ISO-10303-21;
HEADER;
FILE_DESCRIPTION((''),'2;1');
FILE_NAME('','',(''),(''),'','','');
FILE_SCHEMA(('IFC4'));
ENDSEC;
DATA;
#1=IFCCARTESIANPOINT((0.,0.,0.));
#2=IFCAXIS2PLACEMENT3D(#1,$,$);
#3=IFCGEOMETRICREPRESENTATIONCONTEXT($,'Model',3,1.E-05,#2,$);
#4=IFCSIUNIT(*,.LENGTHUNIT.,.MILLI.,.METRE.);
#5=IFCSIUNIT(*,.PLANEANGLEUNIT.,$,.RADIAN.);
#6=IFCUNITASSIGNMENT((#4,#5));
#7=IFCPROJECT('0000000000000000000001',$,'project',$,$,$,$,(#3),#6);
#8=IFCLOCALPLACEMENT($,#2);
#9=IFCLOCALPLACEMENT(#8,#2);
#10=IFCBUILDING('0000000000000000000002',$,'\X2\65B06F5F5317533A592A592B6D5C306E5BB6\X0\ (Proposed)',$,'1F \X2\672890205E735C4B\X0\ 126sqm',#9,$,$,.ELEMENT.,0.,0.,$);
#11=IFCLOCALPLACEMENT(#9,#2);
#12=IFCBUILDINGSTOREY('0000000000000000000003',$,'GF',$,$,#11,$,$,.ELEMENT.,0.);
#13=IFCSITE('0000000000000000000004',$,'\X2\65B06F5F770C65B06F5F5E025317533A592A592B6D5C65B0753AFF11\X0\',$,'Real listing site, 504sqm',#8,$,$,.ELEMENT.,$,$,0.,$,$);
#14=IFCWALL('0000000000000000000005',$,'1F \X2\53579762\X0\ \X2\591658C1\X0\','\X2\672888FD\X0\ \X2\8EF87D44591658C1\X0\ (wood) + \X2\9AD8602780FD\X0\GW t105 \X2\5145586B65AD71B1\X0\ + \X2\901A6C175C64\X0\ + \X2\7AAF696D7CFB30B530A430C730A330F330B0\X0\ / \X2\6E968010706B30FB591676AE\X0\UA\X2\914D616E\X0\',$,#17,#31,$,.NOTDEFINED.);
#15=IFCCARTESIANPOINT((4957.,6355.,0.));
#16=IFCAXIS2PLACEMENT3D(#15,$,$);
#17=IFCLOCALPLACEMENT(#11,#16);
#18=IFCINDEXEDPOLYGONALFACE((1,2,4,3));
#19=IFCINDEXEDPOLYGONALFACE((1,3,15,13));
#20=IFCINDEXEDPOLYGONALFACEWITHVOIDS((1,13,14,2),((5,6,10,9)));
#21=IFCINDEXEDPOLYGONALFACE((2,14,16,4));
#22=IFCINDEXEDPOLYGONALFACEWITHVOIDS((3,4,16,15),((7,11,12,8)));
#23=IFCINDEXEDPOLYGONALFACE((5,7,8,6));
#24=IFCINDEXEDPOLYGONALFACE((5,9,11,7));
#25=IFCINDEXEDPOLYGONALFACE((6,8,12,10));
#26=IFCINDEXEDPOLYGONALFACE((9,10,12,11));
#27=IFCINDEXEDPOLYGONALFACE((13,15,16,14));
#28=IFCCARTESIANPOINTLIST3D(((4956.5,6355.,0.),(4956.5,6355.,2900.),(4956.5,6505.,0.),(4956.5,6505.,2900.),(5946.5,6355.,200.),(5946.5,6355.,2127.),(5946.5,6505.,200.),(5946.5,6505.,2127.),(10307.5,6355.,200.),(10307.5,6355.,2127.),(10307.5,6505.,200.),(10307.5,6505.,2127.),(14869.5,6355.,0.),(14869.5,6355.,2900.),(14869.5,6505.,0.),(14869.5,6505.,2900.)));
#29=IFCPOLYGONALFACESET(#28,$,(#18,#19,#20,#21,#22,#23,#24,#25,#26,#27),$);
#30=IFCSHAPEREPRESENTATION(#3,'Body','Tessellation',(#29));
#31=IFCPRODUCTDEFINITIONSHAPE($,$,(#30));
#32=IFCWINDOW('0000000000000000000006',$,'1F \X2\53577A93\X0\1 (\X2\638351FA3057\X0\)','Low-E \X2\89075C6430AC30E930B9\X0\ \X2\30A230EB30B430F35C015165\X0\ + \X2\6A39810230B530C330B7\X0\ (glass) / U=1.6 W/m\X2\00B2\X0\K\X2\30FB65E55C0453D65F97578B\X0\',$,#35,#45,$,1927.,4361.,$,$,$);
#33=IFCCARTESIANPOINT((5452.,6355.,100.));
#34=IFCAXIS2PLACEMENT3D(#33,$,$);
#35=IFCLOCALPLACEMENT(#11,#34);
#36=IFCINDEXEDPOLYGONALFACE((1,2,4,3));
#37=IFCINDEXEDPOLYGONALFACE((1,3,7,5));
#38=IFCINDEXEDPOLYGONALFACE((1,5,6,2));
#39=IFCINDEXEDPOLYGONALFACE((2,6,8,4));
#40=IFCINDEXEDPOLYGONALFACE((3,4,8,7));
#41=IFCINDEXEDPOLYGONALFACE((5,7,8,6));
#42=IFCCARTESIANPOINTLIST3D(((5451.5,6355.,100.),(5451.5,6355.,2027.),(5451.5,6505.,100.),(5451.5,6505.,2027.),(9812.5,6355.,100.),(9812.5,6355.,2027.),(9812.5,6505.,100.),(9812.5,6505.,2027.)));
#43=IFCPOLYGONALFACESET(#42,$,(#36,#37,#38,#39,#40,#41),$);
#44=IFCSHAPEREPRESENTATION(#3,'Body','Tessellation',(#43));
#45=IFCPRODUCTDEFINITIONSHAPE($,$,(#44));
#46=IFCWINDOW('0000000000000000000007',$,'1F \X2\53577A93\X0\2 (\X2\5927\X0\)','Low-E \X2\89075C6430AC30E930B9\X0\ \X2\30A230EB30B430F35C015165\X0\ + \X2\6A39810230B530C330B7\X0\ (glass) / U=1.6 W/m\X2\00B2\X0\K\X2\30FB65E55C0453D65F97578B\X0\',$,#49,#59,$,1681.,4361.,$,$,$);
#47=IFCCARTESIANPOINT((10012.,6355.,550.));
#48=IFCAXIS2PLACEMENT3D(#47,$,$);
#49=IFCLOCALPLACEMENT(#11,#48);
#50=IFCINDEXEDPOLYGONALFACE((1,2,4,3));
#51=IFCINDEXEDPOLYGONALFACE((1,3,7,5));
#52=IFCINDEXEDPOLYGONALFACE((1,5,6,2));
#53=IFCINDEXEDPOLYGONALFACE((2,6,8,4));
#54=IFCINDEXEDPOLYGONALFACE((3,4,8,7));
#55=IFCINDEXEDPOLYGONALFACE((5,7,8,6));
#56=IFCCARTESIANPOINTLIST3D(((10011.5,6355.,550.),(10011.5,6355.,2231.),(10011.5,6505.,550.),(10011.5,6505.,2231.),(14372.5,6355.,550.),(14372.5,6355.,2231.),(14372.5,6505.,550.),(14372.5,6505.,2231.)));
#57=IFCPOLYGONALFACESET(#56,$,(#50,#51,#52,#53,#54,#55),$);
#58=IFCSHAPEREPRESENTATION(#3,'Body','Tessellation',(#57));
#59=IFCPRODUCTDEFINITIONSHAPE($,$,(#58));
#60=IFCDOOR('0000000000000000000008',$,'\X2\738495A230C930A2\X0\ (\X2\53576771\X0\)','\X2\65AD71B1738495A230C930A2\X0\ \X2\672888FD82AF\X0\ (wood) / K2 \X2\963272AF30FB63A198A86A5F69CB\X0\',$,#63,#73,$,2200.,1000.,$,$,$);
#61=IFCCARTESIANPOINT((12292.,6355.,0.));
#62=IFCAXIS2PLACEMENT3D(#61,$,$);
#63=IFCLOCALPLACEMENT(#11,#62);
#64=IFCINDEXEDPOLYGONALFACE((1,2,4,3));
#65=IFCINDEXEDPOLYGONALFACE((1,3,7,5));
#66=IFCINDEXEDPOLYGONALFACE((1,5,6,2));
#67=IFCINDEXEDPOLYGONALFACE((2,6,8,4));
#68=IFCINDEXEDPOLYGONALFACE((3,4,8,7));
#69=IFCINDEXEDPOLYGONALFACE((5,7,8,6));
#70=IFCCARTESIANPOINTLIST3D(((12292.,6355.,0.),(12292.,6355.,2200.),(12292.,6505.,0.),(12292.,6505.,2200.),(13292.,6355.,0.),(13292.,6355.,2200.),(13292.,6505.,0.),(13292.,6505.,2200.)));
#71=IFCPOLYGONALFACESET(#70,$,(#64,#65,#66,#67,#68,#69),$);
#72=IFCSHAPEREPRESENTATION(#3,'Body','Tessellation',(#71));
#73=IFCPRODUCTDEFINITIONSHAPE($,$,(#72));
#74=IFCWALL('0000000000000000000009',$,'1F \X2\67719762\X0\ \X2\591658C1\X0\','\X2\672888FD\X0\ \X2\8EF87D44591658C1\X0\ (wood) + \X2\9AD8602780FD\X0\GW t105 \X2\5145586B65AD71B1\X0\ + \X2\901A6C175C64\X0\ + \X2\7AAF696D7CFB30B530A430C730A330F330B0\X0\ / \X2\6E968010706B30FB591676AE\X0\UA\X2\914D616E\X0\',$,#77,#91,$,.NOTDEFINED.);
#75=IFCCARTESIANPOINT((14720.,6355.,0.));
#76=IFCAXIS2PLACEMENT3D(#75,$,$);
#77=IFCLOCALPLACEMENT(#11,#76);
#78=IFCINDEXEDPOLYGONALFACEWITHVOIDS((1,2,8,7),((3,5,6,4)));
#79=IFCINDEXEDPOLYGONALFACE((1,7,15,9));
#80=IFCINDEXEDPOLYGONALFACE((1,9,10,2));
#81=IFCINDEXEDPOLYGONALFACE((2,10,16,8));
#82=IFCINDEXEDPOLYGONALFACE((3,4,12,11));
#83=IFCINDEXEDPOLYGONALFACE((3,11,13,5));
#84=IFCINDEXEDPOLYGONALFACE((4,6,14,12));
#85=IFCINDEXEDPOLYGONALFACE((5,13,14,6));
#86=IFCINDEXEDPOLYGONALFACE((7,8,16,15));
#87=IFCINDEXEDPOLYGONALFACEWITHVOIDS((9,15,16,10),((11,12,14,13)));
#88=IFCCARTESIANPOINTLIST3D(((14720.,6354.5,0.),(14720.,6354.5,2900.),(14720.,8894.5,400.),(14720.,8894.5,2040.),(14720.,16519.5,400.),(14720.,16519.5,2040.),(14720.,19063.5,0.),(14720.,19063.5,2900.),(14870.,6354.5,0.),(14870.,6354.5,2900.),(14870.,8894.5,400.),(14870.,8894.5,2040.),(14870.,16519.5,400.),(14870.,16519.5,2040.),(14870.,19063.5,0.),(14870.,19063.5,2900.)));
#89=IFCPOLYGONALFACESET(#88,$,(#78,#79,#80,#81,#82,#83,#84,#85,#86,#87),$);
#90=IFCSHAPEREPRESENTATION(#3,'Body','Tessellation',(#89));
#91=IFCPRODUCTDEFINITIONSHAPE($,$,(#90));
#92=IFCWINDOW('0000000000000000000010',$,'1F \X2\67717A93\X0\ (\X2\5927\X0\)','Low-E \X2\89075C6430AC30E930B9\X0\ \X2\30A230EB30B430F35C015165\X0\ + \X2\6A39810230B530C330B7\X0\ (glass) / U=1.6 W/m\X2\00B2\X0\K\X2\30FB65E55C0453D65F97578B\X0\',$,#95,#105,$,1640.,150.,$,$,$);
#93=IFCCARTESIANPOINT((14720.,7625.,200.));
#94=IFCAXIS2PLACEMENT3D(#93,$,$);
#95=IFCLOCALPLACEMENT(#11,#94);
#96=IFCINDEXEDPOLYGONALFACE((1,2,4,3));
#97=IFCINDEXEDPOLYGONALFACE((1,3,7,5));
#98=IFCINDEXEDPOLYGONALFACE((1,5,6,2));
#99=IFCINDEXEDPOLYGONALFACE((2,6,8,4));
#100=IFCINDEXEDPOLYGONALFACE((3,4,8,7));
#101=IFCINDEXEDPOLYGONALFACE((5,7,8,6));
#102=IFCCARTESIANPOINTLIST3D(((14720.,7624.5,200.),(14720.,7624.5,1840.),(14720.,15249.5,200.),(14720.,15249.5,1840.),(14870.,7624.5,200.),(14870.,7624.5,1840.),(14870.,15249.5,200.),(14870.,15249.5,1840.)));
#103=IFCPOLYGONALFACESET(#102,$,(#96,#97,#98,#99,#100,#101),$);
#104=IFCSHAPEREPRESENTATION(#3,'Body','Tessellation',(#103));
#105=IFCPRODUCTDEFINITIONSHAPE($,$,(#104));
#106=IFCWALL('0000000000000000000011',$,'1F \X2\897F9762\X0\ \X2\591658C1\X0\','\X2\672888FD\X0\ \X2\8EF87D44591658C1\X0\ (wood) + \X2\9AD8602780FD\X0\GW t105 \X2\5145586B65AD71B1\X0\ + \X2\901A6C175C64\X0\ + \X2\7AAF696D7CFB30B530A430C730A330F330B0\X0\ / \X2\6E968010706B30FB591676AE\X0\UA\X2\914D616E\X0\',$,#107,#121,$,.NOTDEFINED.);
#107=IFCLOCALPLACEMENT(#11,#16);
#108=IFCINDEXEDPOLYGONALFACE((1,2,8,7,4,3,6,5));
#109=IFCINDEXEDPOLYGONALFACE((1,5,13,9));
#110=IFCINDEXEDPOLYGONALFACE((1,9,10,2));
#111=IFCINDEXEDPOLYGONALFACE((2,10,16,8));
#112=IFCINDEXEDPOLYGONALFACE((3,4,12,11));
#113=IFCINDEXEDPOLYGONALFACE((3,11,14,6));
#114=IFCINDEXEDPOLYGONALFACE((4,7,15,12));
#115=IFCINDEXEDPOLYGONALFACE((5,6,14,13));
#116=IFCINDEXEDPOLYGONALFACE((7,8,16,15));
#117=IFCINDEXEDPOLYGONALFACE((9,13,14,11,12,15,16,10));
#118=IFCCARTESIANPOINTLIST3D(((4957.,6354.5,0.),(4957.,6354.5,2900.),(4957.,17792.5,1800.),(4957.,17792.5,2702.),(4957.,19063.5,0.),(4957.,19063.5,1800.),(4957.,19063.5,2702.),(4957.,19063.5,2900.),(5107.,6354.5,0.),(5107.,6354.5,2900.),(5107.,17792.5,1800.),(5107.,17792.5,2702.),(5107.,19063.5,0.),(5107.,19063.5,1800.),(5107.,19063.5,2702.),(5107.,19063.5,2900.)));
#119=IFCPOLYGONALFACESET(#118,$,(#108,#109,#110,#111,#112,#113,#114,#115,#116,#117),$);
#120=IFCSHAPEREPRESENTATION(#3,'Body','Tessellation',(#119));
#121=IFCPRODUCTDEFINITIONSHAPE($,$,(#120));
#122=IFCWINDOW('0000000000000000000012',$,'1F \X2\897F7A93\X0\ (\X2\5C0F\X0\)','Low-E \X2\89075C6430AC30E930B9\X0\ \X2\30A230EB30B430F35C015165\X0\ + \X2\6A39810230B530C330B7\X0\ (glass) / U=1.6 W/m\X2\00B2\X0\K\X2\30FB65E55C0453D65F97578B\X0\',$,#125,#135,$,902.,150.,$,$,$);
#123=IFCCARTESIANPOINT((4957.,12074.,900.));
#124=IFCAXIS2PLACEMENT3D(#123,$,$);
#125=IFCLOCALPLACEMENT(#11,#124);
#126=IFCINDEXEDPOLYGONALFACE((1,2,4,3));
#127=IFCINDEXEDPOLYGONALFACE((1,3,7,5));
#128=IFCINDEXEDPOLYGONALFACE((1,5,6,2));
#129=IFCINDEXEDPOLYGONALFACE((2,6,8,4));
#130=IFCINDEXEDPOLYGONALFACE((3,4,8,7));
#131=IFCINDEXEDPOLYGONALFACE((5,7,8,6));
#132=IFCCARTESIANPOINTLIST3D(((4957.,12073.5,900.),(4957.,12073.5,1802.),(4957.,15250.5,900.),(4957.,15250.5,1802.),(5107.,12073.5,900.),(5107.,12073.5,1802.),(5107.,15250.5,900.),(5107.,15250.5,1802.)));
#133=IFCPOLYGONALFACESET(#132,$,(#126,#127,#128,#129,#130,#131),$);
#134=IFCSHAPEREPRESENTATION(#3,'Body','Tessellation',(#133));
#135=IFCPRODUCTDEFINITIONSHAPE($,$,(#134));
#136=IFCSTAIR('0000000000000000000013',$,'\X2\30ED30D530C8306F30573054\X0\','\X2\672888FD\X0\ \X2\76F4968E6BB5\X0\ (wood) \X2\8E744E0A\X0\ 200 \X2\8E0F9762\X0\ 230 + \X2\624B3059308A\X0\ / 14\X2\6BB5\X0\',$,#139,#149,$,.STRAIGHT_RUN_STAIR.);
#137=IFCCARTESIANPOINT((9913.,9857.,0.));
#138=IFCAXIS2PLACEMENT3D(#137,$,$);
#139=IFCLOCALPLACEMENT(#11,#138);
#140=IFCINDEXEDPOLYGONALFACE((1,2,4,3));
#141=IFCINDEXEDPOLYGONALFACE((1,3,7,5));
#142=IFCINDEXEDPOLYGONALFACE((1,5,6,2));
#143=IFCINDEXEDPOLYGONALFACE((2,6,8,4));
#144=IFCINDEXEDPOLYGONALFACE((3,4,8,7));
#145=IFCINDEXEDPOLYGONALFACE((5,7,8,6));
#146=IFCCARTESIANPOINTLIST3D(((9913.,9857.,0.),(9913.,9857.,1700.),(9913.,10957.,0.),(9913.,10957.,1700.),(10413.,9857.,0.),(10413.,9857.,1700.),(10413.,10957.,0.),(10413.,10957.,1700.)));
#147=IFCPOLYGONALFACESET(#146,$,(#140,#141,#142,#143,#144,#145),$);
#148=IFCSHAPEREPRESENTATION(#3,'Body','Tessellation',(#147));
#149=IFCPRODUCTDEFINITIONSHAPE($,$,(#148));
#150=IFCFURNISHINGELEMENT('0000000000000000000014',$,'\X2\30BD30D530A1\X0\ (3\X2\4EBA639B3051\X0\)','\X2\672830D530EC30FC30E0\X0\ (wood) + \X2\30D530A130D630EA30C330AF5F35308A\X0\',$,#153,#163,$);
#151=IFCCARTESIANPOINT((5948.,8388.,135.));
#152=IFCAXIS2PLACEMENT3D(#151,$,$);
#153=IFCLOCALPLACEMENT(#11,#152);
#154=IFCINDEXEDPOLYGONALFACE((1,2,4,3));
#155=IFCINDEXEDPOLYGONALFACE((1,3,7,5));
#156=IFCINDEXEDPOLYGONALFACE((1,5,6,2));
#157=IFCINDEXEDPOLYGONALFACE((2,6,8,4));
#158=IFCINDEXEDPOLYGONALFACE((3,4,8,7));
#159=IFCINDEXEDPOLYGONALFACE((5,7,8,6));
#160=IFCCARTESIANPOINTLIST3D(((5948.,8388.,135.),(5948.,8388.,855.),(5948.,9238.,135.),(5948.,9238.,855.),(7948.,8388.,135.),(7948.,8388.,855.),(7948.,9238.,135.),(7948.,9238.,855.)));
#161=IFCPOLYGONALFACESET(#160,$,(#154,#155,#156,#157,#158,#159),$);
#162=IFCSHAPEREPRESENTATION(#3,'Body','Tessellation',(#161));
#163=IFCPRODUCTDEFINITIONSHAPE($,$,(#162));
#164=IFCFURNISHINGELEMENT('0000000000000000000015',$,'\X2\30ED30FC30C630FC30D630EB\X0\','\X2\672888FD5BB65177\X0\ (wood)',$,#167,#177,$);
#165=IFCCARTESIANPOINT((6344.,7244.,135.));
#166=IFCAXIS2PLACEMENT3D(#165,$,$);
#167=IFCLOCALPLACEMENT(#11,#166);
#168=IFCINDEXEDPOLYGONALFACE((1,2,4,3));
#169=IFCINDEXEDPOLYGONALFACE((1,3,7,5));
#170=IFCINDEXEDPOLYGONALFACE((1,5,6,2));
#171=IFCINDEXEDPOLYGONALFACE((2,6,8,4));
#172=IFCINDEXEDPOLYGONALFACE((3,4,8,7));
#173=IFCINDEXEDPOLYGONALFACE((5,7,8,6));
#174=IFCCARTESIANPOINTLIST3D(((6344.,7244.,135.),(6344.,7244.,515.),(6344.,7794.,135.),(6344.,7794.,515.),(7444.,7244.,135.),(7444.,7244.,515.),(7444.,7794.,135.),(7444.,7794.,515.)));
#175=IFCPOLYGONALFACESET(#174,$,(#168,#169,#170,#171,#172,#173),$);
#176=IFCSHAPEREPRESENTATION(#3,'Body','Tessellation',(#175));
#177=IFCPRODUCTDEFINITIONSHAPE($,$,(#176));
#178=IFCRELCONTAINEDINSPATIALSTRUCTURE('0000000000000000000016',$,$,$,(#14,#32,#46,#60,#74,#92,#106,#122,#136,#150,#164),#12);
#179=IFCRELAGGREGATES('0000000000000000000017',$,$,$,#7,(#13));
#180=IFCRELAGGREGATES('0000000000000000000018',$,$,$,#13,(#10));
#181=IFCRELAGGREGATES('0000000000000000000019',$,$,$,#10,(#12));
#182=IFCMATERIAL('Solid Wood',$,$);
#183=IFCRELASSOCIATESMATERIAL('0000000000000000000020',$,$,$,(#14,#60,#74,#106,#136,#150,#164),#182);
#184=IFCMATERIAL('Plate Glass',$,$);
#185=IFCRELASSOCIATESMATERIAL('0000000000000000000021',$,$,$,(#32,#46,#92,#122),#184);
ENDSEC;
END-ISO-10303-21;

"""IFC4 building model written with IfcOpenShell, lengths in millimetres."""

from ifc_helpers import new_model, si_unit, frame, frame_2d, origin, place, context, project, spatial, rectangle, extrude, material, element, fill, save


model = new_model("IFC4")

# Units and contexts
model_context = context("Model", 3, precision=1e-05, world=origin())
ifc_project = project(units=[si_unit("LENGTHUNIT", "METRE", prefix="MILLI"), si_unit("PLANEANGLEUNIT", "RADIAN")], contexts=[model_context])

# Site, building, storey
site_placement = place(None, origin())
site = spatial("IfcSite", under=ifc_project, at=site_placement, Name="新潟県新潟市北区太夫浜新町１", ObjectType="Real listing site, 504sqm", CompositionType="ELEMENT", RefElevation=0.0)
building_placement = place(site_placement, origin())
building = spatial("IfcBuilding", under=site, at=building_placement, Name="新潟北区太夫浜の家 (Proposed)", ObjectType="1F 木造平屋 126sqm", CompositionType="ELEMENT", ElevationOfRefHeight=0.0, ElevationOfTerrain=0.0)
storey_placement = place(building_placement, origin())
storey = spatial("IfcBuildingStorey", under=building, at=storey_placement, Name="GF", CompositionType="ELEMENT", Elevation=0.0)

# Shared definitions
ifc_material_1 = material(Name="Solid Wood")

# Wall, openings, windows, door
wall_1_placement = place(storey_placement, frame((4957.0, 6355.0, 0.0)))
wall_1 = element("IfcWall", 1, at=wall_1_placement, inside=storey, material=ifc_material_1, Name="1F 南面 外壁", Description="木製 軸組外壁 (wood) + 高性能GW t105 充填断熱 + 通気層 + 窯業系サイディング / 準耐火・外皮UA配慮", PredefinedType="NOTDEFINED", context=model_context, shape_type="SweptSolid", body=[
    extrude(rectangle(XDim=9913.0, YDim=150.0, at=frame_2d((4956.0, 75.0))), frame((4957.0, 6355.0, 0.0)), (0.0, 0.0, 1.0), 2900.0),
])
opening_1_placement = place(storey_placement, frame((5452.0, 6355.0, 100.0)))
opening_1 = element("IfcOpeningElement", 2, at=opening_1_placement, cuts=wall_1, PredefinedType="NOTDEFINED", context=model_context, shape_type="SweptSolid", body=[
    extrude(rectangle(XDim=4361.0, YDim=150.0, at=frame_2d((2180.0, 75.0))), frame((5452.0, 6355.0, 100.0)), (0.0, 0.0, 1.0), 1927.0),
])
opening_2_placement = place(storey_placement, frame((10012.0, 6355.0, 550.0)))
opening_2 = element("IfcOpeningElement", 3, at=opening_2_placement, cuts=wall_1, PredefinedType="NOTDEFINED", context=model_context, shape_type="SweptSolid", body=[
    extrude(rectangle(XDim=4361.0, YDim=150.0, at=frame_2d((2180.0, 75.0))), frame((10012.0, 6355.0, 550.0)), (0.0, 0.0, 1.0), 1681.0),
])
opening_3_placement = place(storey_placement, frame((12292.0, 6355.0, 0.0)))
opening_3 = element("IfcOpeningElement", 4, at=opening_3_placement, cuts=wall_1, PredefinedType="NOTDEFINED", context=model_context, shape_type="SweptSolid", body=[
    extrude(rectangle(XDim=1000.0, YDim=150.0, at=frame_2d((500.0, 75.0))), frame((12292.0, 6355.0, 0.0)), (0.0, 0.0, 1.0), 2200.0),
])
ifc_material_2 = material(Name="Plate Glass")
window_1_placement = place(storey_placement, frame((5452.0, 6355.0, 100.0)))
window_1 = element("IfcWindow", 5, at=window_1_placement, inside=storey, material=ifc_material_2, Name="1F 南窓1 (掃出し)", Description="Low-E 複層ガラス アルゴン封入 + 樹脂サッシ (glass) / U=1.6 W/m²K・日射取得型", OverallHeight=1927.0, OverallWidth=4361.0, context=model_context, shape_type="SweptSolid", body=[
    extrude(rectangle(XDim=4361.0, YDim=150.0, at=frame_2d((2180.0, 75.0))), frame((5452.0, 6355.0, 100.0)), (0.0, 0.0, 1.0), 1927.0),
])
fill(opening_1, window_1)
window_2_placement = place(storey_placement, frame((10012.0, 6355.0, 550.0)))
window_2 = element("IfcWindow", 6, at=window_2_placement, inside=storey, material=ifc_material_2, Name="1F 南窓2 (大)", Description="Low-E 複層ガラス アルゴン封入 + 樹脂サッシ (glass) / U=1.6 W/m²K・日射取得型", OverallHeight=1681.0, OverallWidth=4361.0, context=model_context, shape_type="SweptSolid", body=[
    extrude(rectangle(XDim=4361.0, YDim=150.0, at=frame_2d((2180.0, 75.0))), frame((10012.0, 6355.0, 550.0)), (0.0, 0.0, 1.0), 1681.0),
])
fill(opening_2, window_2)
door_placement = place(storey_placement, frame((12292.0, 6355.0, 0.0)))
door = element("IfcDoor", 7, at=door_placement, inside=storey, material=ifc_material_1, Name="玄関ドア (南東)", Description="断熱玄関ドア 木製芯 (wood) / K2 防犯・採風機構", OverallHeight=2200.0, OverallWidth=1000.0, context=model_context, shape_type="SweptSolid", body=[
    extrude(rectangle(XDim=1000.0, YDim=150.0, at=frame_2d((500.0, 75.0))), frame((12292.0, 6355.0, 0.0)), (0.0, 0.0, 1.0), 2200.0),
])
fill(opening_3, door)

# Walls, openings, windows
wall_2_placement = place(storey_placement, frame((14720.0, 6355.0, 0.0)))
wall_2 = element("IfcWall", 8, at=wall_2_placement, inside=storey, material=ifc_material_1, Name="1F 東面 外壁", Description="木製 軸組外壁 (wood) + 高性能GW t105 充填断熱 + 通気層 + 窯業系サイディング / 準耐火・外皮UA配慮", PredefinedType="NOTDEFINED", context=model_context, shape_type="SweptSolid", body=[
    extrude(rectangle(XDim=150.0, YDim=12709.0, at=frame_2d((75.0, 6354.0))), frame((14720.0, 6355.0, 0.0)), (0.0, 0.0, 1.0), 2900.0),
])
opening_4_placement = place(storey_placement, frame((14720.0, 7625.0, 200.0)))
opening_4 = element("IfcOpeningElement", 9, at=opening_4_placement, cuts=wall_2, PredefinedType="NOTDEFINED", context=model_context, shape_type="SweptSolid", body=[
    extrude(rectangle(XDim=150.0, YDim=7625.0, at=frame_2d((75.0, 3812.0))), frame((14720.0, 7625.0, 200.0)), (0.0, 0.0, 1.0), 1640.0),
])
window_3_placement = place(storey_placement, frame((14720.0, 7625.0, 200.0)))
window_3 = element("IfcWindow", 10, at=window_3_placement, inside=storey, material=ifc_material_2, Name="1F 東窓 (大)", Description="Low-E 複層ガラス アルゴン封入 + 樹脂サッシ (glass) / U=1.6 W/m²K・日射取得型", OverallHeight=1640.0, OverallWidth=150.0, context=model_context, shape_type="SweptSolid", body=[
    extrude(rectangle(XDim=150.0, YDim=7625.0, at=frame_2d((75.0, 3812.0))), frame((14720.0, 7625.0, 200.0)), (0.0, 0.0, 1.0), 1640.0),
])
fill(opening_4, window_3)
wall_3_placement = place(storey_placement, frame((4957.0, 6355.0, 0.0)))
wall_3 = element("IfcWall", 11, at=wall_3_placement, inside=storey, material=ifc_material_1, Name="1F 西面 外壁", Description="木製 軸組外壁 (wood) + 高性能GW t105 充填断熱 + 通気層 + 窯業系サイディング / 準耐火・外皮UA配慮", PredefinedType="NOTDEFINED", context=model_context, shape_type="SweptSolid", body=[
    extrude(rectangle(XDim=150.0, YDim=12709.0, at=frame_2d((75.0, 6354.0))), frame((4957.0, 6355.0, 0.0)), (0.0, 0.0, 1.0), 2900.0),
])
opening_5_placement = place(storey_placement, frame((4957.0, 12074.0, 900.0)))
opening_5 = element("IfcOpeningElement", 12, at=opening_5_placement, cuts=wall_3, PredefinedType="NOTDEFINED", context=model_context, shape_type="SweptSolid", body=[
    extrude(rectangle(XDim=150.0, YDim=3177.0, at=frame_2d((75.0, 1588.0))), frame((4957.0, 12074.0, 900.0)), (0.0, 0.0, 1.0), 902.0),
])
window_4_placement = place(storey_placement, frame((4957.0, 12074.0, 900.0)))
window_4 = element("IfcWindow", 13, at=window_4_placement, inside=storey, material=ifc_material_2, Name="1F 西窓 (小)", Description="Low-E 複層ガラス アルゴン封入 + 樹脂サッシ (glass) / U=1.6 W/m²K・日射取得型", OverallHeight=902.0, OverallWidth=150.0, context=model_context, shape_type="SweptSolid", body=[
    extrude(rectangle(XDim=150.0, YDim=3177.0, at=frame_2d((75.0, 1588.0))), frame((4957.0, 12074.0, 900.0)), (0.0, 0.0, 1.0), 902.0),
])
fill(opening_5, window_4)

# Stair
stair_placement = place(storey_placement, frame((9913.0, 9857.0, 0.0)))
element("IfcStair", 14, at=stair_placement, inside=storey, material=ifc_material_1, Name="ロフトはしご", Description="木製 直階段 (wood) 蹴上 200 踏面 230 + 手すり / 14段", PredefinedType="STRAIGHT_RUN_STAIR", context=model_context, shape_type="SweptSolid", body=[
    extrude(rectangle(XDim=500.0, YDim=1100.0, at=frame_2d((250.0, 550.0))), frame((9913.0, 9857.0, 0.0)), (0.0, 0.0, 1.0), 1700.0),
])

# Furnishing elements
furnishing_1_placement = place(storey_placement, frame((5948.0, 8388.0, 135.0)))
element("IfcFurnishingElement", 15, at=furnishing_1_placement, inside=storey, material=ifc_material_1, Name="ソファ (3人掛け)", Description="木フレーム (wood) + ファブリック張り", context=model_context, shape_type="SweptSolid", body=[
    extrude(rectangle(XDim=2000.0, YDim=850.0, at=frame_2d((1000.0, 425.0))), frame((5948.0, 8388.0, 135.0)), (0.0, 0.0, 1.0), 720.0),
])
furnishing_2_placement = place(storey_placement, frame((6344.0, 7244.0, 135.0)))
element("IfcFurnishingElement", 16, at=furnishing_2_placement, inside=storey, material=ifc_material_1, Name="ローテーブル", Description="木製家具 (wood)", context=model_context, shape_type="SweptSolid", body=[
    extrude(rectangle(XDim=1100.0, YDim=550.0, at=frame_2d((550.0, 275.0))), frame((6344.0, 7244.0, 135.0)), (0.0, 0.0, 1.0), 380.0),
])

save(model, "model.ifc")
